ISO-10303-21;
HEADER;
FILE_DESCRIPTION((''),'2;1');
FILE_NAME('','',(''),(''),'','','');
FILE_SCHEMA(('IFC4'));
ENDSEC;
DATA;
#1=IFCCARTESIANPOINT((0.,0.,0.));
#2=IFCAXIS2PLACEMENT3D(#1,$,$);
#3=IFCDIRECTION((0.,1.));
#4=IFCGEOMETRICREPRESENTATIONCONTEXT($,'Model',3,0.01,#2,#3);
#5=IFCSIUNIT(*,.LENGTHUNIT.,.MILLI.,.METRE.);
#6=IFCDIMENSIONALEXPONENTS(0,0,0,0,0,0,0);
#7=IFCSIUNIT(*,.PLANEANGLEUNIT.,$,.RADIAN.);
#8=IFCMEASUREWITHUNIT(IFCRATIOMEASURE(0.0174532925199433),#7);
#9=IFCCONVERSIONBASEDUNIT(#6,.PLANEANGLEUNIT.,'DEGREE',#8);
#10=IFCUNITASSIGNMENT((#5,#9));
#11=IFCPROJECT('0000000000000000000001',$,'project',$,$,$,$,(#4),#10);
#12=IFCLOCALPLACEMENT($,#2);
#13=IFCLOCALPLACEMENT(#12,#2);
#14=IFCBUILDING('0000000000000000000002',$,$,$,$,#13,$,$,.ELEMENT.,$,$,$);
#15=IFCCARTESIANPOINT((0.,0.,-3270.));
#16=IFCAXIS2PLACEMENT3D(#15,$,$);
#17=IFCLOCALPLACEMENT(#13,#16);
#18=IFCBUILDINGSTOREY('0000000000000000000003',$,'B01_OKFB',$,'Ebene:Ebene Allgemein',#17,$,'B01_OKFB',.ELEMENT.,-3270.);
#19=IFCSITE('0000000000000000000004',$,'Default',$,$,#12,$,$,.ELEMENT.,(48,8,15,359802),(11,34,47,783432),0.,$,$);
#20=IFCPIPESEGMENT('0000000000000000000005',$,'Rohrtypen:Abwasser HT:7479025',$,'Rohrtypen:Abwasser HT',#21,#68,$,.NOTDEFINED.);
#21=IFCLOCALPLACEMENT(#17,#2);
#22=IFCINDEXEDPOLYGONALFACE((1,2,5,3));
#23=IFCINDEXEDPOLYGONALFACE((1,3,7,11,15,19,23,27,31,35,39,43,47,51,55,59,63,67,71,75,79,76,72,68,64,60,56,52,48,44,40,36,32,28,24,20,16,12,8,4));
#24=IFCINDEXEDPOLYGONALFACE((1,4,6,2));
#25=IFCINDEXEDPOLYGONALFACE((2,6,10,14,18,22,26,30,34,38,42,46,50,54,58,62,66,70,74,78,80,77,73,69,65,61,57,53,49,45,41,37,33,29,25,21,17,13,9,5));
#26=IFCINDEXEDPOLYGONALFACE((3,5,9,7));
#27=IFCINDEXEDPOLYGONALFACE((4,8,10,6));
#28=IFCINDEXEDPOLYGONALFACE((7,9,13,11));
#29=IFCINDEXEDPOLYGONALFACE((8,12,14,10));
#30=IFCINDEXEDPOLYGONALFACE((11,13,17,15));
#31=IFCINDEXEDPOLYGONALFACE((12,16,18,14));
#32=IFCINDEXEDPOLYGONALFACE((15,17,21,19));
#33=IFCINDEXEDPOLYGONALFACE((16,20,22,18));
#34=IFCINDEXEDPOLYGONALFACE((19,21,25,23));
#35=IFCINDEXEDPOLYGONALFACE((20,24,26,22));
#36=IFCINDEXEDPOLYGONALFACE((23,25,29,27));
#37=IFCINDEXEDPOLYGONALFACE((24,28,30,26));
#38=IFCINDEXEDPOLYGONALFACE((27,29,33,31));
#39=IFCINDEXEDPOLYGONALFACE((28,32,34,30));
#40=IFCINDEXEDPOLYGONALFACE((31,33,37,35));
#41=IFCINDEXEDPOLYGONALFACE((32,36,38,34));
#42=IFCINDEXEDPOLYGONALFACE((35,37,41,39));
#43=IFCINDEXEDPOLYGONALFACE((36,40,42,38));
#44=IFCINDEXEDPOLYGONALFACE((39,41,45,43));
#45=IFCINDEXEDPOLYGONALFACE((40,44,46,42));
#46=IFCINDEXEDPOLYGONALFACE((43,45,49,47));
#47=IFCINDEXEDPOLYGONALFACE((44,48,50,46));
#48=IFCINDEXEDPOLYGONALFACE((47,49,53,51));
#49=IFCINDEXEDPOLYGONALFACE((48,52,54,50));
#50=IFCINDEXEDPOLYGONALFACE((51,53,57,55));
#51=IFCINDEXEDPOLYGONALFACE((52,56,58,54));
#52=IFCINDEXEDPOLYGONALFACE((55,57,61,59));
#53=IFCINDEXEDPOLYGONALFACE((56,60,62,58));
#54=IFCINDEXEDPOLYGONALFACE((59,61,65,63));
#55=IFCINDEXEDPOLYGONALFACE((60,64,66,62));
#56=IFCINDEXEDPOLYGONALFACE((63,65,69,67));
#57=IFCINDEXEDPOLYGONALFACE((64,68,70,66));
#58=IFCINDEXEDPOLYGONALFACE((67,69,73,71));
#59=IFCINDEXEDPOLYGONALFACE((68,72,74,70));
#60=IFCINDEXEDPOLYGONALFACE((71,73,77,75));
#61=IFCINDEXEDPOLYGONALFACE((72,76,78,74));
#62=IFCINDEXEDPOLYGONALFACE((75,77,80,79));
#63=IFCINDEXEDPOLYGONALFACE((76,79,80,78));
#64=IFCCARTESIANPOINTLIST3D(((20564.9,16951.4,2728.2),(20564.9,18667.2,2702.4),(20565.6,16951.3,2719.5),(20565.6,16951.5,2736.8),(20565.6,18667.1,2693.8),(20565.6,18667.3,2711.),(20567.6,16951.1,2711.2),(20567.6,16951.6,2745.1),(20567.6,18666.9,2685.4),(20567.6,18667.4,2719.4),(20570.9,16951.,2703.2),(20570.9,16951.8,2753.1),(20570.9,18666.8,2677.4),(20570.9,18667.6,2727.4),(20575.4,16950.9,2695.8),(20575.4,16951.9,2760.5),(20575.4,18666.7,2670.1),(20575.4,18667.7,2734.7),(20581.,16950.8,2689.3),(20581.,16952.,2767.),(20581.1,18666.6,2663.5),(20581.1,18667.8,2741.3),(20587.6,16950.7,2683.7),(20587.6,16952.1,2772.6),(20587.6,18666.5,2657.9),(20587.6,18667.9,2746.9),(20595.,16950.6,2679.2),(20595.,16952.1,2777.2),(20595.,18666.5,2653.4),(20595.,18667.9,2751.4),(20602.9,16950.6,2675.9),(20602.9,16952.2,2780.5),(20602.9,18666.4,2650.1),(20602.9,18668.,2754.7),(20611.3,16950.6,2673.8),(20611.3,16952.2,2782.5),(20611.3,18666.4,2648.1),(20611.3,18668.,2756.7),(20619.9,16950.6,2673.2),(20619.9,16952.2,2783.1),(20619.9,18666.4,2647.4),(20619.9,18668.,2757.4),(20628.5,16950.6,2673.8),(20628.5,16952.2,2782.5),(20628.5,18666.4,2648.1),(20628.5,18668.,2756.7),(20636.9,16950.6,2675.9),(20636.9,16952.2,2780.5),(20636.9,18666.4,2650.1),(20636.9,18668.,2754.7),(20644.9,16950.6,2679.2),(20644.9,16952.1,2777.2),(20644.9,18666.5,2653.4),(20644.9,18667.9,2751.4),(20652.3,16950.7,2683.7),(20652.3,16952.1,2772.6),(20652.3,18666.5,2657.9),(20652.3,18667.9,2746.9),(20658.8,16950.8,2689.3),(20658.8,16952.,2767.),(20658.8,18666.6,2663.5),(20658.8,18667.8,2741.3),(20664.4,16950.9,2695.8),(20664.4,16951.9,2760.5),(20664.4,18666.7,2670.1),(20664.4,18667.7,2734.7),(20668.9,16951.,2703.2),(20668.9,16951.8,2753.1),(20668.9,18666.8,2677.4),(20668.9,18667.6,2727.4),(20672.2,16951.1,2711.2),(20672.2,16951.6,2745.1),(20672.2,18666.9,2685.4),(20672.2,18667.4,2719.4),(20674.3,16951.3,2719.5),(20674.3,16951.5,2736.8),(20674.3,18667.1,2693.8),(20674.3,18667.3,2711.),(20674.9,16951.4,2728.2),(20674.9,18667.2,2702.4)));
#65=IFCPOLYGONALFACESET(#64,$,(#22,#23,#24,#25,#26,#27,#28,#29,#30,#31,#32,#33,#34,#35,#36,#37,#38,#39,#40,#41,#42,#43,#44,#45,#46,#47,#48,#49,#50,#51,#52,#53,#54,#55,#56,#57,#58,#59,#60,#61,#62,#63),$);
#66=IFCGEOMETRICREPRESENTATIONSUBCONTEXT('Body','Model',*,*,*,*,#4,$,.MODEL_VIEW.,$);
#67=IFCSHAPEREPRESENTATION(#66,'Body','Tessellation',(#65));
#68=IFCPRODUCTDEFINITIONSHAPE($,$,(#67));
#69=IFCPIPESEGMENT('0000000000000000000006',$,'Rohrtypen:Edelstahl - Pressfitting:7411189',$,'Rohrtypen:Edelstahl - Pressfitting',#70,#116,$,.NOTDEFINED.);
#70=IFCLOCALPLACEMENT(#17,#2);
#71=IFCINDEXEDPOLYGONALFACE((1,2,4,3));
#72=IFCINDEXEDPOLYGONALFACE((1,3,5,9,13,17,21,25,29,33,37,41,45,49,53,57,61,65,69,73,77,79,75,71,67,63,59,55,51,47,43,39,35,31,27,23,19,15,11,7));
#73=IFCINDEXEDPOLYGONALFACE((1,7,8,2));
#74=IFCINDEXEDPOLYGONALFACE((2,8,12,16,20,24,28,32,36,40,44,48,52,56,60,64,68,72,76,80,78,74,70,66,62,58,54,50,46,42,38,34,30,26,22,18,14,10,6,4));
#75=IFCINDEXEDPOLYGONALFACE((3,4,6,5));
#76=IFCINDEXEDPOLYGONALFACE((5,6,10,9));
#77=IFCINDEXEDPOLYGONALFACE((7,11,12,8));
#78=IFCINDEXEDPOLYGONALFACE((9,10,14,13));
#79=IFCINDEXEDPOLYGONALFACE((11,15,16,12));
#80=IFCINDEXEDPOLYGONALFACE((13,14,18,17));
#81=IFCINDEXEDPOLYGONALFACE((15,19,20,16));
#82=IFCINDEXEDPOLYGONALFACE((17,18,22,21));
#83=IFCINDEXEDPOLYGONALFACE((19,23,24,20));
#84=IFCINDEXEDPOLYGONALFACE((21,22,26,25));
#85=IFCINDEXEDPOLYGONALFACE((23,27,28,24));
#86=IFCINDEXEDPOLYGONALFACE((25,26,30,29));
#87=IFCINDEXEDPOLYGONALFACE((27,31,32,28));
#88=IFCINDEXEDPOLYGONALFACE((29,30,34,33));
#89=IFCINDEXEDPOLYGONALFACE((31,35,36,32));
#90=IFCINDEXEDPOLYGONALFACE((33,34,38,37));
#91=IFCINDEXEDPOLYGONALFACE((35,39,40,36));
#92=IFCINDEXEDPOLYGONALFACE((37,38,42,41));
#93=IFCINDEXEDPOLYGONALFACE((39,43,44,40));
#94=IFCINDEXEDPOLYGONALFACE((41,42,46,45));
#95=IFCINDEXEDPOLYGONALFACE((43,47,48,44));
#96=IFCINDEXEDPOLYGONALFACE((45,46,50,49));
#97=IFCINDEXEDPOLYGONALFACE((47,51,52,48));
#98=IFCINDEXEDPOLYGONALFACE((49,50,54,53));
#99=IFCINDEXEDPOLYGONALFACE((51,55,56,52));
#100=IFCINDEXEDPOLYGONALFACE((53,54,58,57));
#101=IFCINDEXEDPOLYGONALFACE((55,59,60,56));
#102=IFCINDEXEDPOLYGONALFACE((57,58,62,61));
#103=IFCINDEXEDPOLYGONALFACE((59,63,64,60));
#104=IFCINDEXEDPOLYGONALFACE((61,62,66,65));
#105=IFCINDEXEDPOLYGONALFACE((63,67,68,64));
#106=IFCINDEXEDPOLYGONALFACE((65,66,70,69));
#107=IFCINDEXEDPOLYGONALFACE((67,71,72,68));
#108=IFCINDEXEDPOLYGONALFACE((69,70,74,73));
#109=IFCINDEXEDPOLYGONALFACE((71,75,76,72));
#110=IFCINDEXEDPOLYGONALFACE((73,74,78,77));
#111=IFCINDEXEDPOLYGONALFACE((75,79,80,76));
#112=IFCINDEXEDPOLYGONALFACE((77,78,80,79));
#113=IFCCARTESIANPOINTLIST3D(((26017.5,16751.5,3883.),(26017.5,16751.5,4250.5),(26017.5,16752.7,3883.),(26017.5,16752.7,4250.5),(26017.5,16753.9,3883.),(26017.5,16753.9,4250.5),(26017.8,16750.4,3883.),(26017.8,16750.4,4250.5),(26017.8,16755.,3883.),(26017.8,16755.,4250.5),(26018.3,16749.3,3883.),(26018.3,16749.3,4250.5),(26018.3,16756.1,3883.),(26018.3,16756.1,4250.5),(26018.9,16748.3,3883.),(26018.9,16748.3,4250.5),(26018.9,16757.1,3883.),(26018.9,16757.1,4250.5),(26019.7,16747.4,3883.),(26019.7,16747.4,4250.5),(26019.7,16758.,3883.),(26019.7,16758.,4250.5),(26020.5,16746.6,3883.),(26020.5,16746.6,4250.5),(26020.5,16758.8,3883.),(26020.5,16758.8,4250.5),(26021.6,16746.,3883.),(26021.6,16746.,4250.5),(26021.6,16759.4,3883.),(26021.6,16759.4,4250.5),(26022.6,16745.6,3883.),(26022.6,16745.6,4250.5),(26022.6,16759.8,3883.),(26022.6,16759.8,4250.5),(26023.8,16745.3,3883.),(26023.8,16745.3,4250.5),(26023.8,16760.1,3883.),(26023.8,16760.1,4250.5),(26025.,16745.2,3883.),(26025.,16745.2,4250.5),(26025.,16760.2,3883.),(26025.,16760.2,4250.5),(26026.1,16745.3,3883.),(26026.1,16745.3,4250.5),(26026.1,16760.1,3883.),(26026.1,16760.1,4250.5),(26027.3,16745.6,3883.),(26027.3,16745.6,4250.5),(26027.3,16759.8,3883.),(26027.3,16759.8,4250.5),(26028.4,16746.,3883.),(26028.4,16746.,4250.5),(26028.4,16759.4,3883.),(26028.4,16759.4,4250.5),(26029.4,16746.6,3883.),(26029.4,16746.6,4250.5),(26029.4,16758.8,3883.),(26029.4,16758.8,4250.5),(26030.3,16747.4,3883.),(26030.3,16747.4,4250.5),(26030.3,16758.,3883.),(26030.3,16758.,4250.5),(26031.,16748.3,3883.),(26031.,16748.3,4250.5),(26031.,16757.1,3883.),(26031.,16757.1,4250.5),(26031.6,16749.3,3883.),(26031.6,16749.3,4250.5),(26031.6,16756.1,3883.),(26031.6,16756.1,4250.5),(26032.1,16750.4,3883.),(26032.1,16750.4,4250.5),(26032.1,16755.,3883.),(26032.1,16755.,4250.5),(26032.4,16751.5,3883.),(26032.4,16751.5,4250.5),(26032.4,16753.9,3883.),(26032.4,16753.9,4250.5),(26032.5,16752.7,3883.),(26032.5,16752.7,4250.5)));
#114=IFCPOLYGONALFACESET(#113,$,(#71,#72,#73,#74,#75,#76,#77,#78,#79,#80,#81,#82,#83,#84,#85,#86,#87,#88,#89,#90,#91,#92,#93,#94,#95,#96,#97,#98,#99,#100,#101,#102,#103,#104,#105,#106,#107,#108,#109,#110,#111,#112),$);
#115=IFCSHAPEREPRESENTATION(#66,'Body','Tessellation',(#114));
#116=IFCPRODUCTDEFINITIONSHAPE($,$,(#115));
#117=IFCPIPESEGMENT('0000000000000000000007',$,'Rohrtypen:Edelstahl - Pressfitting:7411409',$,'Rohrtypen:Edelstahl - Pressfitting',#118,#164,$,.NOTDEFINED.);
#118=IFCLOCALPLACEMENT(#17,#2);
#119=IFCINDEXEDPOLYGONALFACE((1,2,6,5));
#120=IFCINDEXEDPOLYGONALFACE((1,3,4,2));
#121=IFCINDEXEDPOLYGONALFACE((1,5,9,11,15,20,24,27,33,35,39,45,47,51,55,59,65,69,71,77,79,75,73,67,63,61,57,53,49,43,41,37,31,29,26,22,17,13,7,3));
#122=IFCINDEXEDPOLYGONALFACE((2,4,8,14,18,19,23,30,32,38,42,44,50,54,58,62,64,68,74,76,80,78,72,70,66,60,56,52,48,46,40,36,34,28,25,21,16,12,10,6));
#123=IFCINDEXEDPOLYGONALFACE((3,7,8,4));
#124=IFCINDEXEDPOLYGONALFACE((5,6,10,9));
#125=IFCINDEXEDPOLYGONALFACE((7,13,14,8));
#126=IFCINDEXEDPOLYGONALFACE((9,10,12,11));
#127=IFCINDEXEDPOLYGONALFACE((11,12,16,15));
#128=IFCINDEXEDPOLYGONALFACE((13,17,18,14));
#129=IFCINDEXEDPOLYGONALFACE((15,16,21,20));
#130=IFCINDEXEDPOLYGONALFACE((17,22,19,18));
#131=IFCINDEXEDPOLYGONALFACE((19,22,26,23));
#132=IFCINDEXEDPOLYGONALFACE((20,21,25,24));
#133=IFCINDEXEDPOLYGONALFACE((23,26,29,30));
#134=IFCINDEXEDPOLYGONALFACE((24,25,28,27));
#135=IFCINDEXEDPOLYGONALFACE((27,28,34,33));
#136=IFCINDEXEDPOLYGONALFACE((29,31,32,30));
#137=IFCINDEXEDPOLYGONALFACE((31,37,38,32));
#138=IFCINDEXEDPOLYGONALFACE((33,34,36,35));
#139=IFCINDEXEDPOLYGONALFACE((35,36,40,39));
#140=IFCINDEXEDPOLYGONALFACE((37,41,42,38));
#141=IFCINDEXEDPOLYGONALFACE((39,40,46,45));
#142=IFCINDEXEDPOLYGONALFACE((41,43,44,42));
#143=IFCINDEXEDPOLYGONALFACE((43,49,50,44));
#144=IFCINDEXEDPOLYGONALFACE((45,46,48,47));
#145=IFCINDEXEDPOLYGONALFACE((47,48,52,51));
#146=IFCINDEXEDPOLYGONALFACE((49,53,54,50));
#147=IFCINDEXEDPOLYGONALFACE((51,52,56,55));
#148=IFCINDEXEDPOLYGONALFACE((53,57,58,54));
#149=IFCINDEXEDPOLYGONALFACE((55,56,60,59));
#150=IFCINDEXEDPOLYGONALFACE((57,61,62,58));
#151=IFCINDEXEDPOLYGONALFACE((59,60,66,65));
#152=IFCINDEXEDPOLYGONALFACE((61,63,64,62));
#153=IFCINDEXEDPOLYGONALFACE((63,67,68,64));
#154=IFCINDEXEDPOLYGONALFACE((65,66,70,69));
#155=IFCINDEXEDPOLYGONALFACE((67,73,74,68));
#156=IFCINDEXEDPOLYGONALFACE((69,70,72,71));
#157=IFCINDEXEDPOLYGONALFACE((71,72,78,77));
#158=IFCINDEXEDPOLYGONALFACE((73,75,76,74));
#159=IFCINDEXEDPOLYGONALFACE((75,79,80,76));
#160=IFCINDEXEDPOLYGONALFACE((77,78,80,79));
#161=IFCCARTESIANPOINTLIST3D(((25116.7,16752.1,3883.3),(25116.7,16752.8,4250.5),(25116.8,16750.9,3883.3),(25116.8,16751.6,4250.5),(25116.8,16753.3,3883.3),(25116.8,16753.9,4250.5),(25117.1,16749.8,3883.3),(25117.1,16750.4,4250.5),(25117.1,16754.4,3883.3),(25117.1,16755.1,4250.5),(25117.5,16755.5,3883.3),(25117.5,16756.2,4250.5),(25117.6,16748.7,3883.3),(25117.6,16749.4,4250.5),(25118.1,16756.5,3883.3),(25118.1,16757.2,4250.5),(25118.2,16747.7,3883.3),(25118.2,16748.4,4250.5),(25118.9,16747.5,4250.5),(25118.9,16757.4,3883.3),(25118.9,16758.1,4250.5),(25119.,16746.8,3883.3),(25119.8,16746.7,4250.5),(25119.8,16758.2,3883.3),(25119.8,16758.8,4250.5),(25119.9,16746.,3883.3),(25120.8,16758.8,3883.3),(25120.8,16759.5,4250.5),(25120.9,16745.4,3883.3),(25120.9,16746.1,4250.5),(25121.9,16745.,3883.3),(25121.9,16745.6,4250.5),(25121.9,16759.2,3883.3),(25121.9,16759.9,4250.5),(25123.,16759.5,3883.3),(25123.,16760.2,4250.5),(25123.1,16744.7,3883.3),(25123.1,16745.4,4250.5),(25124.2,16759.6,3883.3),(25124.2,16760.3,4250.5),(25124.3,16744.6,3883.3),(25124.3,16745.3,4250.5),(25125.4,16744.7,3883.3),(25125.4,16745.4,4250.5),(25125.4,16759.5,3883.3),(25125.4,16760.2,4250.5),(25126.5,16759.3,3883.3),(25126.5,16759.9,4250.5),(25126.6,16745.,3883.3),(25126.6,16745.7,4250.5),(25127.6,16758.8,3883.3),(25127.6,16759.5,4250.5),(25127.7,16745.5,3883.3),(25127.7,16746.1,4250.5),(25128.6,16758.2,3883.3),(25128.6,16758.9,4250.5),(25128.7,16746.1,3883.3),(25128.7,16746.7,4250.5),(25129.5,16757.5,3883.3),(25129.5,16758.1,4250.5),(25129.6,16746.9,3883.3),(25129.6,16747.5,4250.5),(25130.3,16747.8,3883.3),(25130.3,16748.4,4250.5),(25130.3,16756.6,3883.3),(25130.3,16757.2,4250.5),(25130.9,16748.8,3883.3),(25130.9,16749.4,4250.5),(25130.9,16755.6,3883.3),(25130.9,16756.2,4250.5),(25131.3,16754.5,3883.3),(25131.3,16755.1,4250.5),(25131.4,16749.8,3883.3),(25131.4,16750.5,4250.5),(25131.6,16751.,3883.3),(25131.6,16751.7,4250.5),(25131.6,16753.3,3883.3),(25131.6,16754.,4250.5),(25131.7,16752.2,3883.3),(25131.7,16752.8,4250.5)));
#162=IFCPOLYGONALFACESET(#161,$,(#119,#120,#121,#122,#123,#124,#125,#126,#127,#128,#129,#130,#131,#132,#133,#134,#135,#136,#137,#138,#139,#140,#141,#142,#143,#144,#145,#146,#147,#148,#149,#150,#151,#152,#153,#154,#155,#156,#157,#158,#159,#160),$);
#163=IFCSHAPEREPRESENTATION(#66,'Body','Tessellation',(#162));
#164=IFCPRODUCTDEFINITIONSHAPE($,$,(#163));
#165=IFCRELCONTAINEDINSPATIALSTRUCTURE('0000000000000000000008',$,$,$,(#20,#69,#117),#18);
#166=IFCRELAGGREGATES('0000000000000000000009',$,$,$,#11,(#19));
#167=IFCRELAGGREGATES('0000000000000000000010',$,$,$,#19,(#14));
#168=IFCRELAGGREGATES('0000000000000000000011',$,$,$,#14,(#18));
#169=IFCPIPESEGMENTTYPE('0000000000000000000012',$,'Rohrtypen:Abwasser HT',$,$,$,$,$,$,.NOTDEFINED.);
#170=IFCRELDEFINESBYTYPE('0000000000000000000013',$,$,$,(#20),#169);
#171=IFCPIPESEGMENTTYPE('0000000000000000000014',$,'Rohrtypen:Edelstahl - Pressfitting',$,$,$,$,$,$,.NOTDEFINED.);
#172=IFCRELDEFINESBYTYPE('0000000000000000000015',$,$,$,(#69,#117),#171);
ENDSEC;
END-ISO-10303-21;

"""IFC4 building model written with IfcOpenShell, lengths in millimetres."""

from ifc_helpers import new_model, entity, si_unit, converted_unit, direction, frame, origin, place, context, subcontext, project, spatial, indexed_curve, outline, extrude, type_object, element, save


model = new_model("IFC4")

# Units and contexts
model_context = context("Model", 3, precision=0.01, world=origin(), true_north=direction((0.0, 1.0)))
body_context = subcontext(model_context, "Body", "Model", "MODEL_VIEW")
ifc_project = project(units=[si_unit("LENGTHUNIT", "METRE", prefix="MILLI"), converted_unit("PLANEANGLEUNIT", "DEGREE", entity("IfcRatioMeasure", 0.0174532925199433), si_unit("PLANEANGLEUNIT", "RADIAN"), dimensions=[0, 0, 0, 0, 0, 0, 0])], contexts=[model_context])

# Site, building, storey
site_placement = place(None, origin())
site = spatial("IfcSite", under=ifc_project, at=site_placement, Name="Default", CompositionType="ELEMENT", RefLatitude=(48, 8, 15, 359802), RefLongitude=(11, 34, 47, 783432), RefElevation=0.0)
building_placement = place(site_placement, origin())
building = spatial("IfcBuilding", under=site, at=building_placement, CompositionType="ELEMENT")
storey_placement = place(building_placement, frame((0.0, 0.0, -3270.0)))
storey = spatial("IfcBuildingStorey", under=building, at=storey_placement, Name="B01_OKFB", ObjectType="Ebene:Ebene Allgemein", LongName="B01_OKFB", CompositionType="ELEMENT", Elevation=-3270.0)

# Pipe segments
pipe_segment_type_1 = type_object("IfcPipeSegmentType", Name="Rohrtypen:Abwasser HT", PredefinedType="NOTDEFINED")
pipe_segment_1_placement = place(storey_placement, origin())
element("IfcPipeSegment", 1, at=pipe_segment_1_placement, inside=storey, type_object=pipe_segment_type_1, Name="Rohrtypen:Abwasser HT:7479025", ObjectType="Rohrtypen:Abwasser HT", PredefinedType="NOTDEFINED", context=body_context, shape_type="SweptSolid", body=[
    extrude(outline(indexed_curve([(55.0, 0.0), (54.3, 8.6), (52.3, 17.0), (49.0, 25.0), (44.5, 32.3), (38.9, 38.9), (32.3, 44.5), (25.0, 49.0), (17.0, 52.3), (8.6, 54.3), (0.0, 55.0), (-8.6, 54.3), (-17.0, 52.3), (-25.0, 49.0), (-32.3, 44.5), (-38.9, 38.9), (-44.5, 32.3), (-49.0, 25.0), (-52.3, 17.0), (-54.3, 8.6), (-55.0, 0.0), (-54.3, -8.6), (-52.3, -17.0), (-49.0, -25.0), (-44.5, -32.3), (-38.9, -38.9), (-32.3, -44.5), (-25.0, -49.0), (-17.0, -52.3), (-8.6, -54.3), (0.0, -55.0), (8.6, -54.3), (17.0, -52.3), (25.0, -49.0), (32.3, -44.5), (38.9, -38.9), (44.5, -32.3), (49.0, -25.0), (52.3, -17.0), (54.3, -8.6), (55.0, 0.0)], self_intersect=False)), frame((20619.9, 16951.4, 2728.2), z_axis=(0.000002, 0.999888, -0.014998), x_axis=(1.0, -0.000002, 0.0)), (0.0, 0.0, 1.0), 1716.0),
])
pipe_segment_type_2 = type_object("IfcPipeSegmentType", Name="Rohrtypen:Edelstahl - Pressfitting", PredefinedType="NOTDEFINED")
pipe_segment_2_placement = place(storey_placement, origin())
element("IfcPipeSegment", 2, at=pipe_segment_2_placement, inside=storey, type_object=pipe_segment_type_2, Name="Rohrtypen:Edelstahl - Pressfitting:7411189", ObjectType="Rohrtypen:Edelstahl - Pressfitting", PredefinedType="NOTDEFINED", context=body_context, shape_type="SweptSolid", body=[
    extrude(outline(indexed_curve([(7.5, 0.0), (7.4, 1.2), (7.1, 2.3), (6.7, 3.4), (6.1, 4.4), (5.3, 5.3), (4.4, 6.1), (3.4, 6.7), (2.3, 7.1), (1.2, 7.4), (0.0, 7.5), (-1.2, 7.4), (-2.3, 7.1), (-3.4, 6.7), (-4.4, 6.1), (-5.3, 5.3), (-6.1, 4.4), (-6.7, 3.4), (-7.1, 2.3), (-7.4, 1.2), (-7.5, 0.0), (-7.4, -1.2), (-7.1, -2.3), (-6.7, -3.4), (-6.1, -4.4), (-5.3, -5.3), (-4.4, -6.1), (-3.4, -6.7), (-2.3, -7.1), (-1.2, -7.4), (0.0, -7.5), (1.2, -7.4), (2.3, -7.1), (3.4, -6.7), (4.4, -6.1), (5.3, -5.3), (6.1, -4.4), (6.7, -3.4), (7.1, -2.3), (7.4, -1.2), (7.5, 0.0)], self_intersect=False)), frame((26025.0, 16752.7, 3883.0), z_axis=(0.0, 0.0, 1.0), x_axis=(-1.0, 0.0, 0.0)), (0.0, 0.0, 1.0), 367.5),
])
pipe_segment_3_placement = place(storey_placement, origin())
element("IfcPipeSegment", 3, at=pipe_segment_3_placement, inside=storey, type_object=pipe_segment_type_2, Name="Rohrtypen:Edelstahl - Pressfitting:7411409", ObjectType="Rohrtypen:Edelstahl - Pressfitting", PredefinedType="NOTDEFINED", context=body_context, shape_type="SweptSolid", body=[
    extrude(outline(indexed_curve([(7.5, 0.0), (7.4, 1.2), (7.1, 2.3), (6.7, 3.4), (6.1, 4.4), (5.3, 5.3), (4.4, 6.1), (3.4, 6.7), (2.3, 7.1), (1.2, 7.4), (0.0, 7.5), (-1.2, 7.4), (-2.3, 7.1), (-3.4, 6.7), (-4.4, 6.1), (-5.3, 5.3), (-6.1, 4.4), (-6.7, 3.4), (-7.1, 2.3), (-7.4, 1.2), (-7.5, 0.0), (-7.4, -1.2), (-7.1, -2.3), (-6.7, -3.4), (-6.1, -4.4), (-5.3, -5.3), (-4.4, -6.1), (-3.4, -6.7), (-2.3, -7.1), (-1.2, -7.4), (0.0, -7.5), (1.2, -7.4), (2.3, -7.1), (3.4, -6.7), (4.4, -6.1), (5.3, -5.3), (6.1, -4.4), (6.7, -3.4), (7.1, -2.3), (7.4, -1.2), (7.5, 0.0)], self_intersect=False)), frame((25124.2, 16752.1, 3883.3), z_axis=(-0.00001, 0.00181, 0.999998), x_axis=(0.999985, 0.005406, 0.0)), (0.0, 0.0, 1.0), 367.2),
])

save(model, "model.ifc")
